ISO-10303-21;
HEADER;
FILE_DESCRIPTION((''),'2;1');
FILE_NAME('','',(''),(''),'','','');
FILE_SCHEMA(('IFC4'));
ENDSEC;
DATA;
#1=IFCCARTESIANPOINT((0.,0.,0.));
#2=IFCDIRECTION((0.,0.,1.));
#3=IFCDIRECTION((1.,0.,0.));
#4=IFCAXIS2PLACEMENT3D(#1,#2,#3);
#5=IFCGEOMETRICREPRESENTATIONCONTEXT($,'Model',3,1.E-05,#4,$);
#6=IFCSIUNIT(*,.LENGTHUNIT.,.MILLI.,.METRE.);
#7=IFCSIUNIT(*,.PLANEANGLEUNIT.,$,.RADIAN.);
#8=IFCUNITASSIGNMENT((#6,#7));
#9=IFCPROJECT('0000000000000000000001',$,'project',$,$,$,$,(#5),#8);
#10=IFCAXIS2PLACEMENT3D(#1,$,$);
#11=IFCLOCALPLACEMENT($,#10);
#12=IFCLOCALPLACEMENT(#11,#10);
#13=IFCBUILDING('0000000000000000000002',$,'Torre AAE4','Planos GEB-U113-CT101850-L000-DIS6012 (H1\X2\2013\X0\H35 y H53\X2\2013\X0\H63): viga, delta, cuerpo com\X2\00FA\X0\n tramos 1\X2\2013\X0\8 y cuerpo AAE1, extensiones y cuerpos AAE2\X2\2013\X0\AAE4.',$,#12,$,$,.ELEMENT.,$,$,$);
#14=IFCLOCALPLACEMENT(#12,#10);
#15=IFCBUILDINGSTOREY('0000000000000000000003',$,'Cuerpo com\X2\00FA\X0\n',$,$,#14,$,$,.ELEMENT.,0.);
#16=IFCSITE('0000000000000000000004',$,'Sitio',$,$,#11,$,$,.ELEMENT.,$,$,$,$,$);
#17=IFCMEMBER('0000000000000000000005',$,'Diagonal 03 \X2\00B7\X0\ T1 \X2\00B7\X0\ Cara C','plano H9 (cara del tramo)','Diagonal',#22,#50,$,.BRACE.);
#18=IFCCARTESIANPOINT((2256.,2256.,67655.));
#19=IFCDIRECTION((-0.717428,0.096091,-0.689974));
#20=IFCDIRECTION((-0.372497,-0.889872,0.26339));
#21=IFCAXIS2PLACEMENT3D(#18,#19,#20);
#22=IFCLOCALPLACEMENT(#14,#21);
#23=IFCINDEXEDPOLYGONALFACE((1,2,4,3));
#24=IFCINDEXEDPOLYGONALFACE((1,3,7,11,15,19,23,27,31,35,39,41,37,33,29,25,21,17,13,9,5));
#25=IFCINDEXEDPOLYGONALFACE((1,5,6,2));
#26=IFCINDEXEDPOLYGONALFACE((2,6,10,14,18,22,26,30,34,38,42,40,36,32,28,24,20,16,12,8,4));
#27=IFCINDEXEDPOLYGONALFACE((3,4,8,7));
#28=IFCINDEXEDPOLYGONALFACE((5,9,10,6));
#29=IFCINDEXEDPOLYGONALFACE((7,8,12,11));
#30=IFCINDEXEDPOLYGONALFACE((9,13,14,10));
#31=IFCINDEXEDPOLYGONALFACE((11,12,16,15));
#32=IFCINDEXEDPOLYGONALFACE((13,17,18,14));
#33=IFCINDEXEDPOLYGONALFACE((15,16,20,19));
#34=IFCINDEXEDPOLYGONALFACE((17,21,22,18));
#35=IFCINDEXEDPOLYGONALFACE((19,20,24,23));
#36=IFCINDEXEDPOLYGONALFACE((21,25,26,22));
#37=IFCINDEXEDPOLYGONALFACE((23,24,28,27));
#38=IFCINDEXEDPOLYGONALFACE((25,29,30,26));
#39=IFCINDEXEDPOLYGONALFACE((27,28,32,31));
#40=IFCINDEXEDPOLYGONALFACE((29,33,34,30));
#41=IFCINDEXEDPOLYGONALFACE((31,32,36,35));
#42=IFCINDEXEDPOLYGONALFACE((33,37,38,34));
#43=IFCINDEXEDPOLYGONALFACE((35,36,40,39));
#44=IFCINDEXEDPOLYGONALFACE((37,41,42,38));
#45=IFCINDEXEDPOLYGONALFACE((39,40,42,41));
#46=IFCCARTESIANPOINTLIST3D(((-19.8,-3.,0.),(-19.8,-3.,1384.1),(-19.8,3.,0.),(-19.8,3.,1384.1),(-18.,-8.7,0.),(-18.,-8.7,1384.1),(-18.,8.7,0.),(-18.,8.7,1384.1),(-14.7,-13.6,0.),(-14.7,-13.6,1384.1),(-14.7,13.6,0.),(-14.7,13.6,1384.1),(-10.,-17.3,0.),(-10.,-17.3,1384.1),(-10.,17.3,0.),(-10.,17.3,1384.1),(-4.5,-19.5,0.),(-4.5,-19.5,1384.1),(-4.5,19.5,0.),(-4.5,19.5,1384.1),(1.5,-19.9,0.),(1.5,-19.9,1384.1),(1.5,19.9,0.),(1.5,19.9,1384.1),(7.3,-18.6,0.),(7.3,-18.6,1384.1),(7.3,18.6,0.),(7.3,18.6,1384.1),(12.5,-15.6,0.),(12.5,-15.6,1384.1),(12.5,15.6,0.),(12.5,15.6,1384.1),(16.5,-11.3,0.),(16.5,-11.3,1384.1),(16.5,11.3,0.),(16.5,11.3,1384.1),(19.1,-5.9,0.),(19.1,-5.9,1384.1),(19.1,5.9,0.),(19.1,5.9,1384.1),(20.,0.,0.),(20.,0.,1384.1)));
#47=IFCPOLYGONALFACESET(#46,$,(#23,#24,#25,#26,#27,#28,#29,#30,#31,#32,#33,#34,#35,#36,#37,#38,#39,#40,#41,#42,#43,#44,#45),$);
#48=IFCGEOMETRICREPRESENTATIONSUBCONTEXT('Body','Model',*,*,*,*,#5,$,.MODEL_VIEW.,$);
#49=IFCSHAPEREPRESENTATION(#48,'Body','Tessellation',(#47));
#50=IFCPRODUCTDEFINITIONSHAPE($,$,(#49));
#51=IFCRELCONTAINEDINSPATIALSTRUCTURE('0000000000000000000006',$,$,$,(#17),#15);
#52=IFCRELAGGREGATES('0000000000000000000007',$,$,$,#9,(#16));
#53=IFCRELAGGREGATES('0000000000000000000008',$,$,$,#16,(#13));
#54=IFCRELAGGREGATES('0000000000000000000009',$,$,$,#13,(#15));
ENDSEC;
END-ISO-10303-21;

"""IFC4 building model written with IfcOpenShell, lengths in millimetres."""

from ifc_helpers import new_model, si_unit, frame, origin, origin_with_axes, place, context, subcontext, project, spatial, circle, extrude, element, save


model = new_model("IFC4")

# Units and contexts
model_context = context("Model", 3, precision=1e-05, world=origin_with_axes())
body_context = subcontext(model_context, "Body", "Model", "MODEL_VIEW")
ifc_project = project(units=[si_unit("LENGTHUNIT", "METRE", prefix="MILLI"), si_unit("PLANEANGLEUNIT", "RADIAN")], contexts=[model_context])

# Site, building, storey
site_placement = place(None, origin())
site = spatial("IfcSite", under=ifc_project, at=site_placement, Name="Sitio", CompositionType="ELEMENT")
building_placement = place(site_placement, origin())
building = spatial("IfcBuilding", under=site, at=building_placement, Name="Torre AAE4", Description="Planos GEB-U113-CT101850-L000-DIS6012 (H1–H35 y H53–H63): viga, delta, cuerpo común tramos 1–8 y cuerpo AAE1, extensiones y cuerpos AAE2–AAE4.", CompositionType="ELEMENT")
storey_placement = place(building_placement, origin())
storey = spatial("IfcBuildingStorey", under=building, at=storey_placement, Name="Cuerpo común", CompositionType="ELEMENT", Elevation=0.0)

# Member
member_1_placement = place(storey_placement, frame((2256.0, 2256.0, 67655.0), z_axis=(-0.717428, 0.096091, -0.689974), x_axis=(-0.372497, -0.889872, 0.26339)))
element("IfcMember", 1, at=member_1_placement, inside=storey, Name="Diagonal 03 · T1 · Cara C", Description="plano H9 (cara del tramo)", ObjectType="Diagonal", PredefinedType="BRACE", context=body_context, shape_type="SweptSolid", body=[
    extrude(circle(Radius=20.0), None, (0.0, 0.0, 1.0), 1384.1),
])

save(model, "model.ifc")
